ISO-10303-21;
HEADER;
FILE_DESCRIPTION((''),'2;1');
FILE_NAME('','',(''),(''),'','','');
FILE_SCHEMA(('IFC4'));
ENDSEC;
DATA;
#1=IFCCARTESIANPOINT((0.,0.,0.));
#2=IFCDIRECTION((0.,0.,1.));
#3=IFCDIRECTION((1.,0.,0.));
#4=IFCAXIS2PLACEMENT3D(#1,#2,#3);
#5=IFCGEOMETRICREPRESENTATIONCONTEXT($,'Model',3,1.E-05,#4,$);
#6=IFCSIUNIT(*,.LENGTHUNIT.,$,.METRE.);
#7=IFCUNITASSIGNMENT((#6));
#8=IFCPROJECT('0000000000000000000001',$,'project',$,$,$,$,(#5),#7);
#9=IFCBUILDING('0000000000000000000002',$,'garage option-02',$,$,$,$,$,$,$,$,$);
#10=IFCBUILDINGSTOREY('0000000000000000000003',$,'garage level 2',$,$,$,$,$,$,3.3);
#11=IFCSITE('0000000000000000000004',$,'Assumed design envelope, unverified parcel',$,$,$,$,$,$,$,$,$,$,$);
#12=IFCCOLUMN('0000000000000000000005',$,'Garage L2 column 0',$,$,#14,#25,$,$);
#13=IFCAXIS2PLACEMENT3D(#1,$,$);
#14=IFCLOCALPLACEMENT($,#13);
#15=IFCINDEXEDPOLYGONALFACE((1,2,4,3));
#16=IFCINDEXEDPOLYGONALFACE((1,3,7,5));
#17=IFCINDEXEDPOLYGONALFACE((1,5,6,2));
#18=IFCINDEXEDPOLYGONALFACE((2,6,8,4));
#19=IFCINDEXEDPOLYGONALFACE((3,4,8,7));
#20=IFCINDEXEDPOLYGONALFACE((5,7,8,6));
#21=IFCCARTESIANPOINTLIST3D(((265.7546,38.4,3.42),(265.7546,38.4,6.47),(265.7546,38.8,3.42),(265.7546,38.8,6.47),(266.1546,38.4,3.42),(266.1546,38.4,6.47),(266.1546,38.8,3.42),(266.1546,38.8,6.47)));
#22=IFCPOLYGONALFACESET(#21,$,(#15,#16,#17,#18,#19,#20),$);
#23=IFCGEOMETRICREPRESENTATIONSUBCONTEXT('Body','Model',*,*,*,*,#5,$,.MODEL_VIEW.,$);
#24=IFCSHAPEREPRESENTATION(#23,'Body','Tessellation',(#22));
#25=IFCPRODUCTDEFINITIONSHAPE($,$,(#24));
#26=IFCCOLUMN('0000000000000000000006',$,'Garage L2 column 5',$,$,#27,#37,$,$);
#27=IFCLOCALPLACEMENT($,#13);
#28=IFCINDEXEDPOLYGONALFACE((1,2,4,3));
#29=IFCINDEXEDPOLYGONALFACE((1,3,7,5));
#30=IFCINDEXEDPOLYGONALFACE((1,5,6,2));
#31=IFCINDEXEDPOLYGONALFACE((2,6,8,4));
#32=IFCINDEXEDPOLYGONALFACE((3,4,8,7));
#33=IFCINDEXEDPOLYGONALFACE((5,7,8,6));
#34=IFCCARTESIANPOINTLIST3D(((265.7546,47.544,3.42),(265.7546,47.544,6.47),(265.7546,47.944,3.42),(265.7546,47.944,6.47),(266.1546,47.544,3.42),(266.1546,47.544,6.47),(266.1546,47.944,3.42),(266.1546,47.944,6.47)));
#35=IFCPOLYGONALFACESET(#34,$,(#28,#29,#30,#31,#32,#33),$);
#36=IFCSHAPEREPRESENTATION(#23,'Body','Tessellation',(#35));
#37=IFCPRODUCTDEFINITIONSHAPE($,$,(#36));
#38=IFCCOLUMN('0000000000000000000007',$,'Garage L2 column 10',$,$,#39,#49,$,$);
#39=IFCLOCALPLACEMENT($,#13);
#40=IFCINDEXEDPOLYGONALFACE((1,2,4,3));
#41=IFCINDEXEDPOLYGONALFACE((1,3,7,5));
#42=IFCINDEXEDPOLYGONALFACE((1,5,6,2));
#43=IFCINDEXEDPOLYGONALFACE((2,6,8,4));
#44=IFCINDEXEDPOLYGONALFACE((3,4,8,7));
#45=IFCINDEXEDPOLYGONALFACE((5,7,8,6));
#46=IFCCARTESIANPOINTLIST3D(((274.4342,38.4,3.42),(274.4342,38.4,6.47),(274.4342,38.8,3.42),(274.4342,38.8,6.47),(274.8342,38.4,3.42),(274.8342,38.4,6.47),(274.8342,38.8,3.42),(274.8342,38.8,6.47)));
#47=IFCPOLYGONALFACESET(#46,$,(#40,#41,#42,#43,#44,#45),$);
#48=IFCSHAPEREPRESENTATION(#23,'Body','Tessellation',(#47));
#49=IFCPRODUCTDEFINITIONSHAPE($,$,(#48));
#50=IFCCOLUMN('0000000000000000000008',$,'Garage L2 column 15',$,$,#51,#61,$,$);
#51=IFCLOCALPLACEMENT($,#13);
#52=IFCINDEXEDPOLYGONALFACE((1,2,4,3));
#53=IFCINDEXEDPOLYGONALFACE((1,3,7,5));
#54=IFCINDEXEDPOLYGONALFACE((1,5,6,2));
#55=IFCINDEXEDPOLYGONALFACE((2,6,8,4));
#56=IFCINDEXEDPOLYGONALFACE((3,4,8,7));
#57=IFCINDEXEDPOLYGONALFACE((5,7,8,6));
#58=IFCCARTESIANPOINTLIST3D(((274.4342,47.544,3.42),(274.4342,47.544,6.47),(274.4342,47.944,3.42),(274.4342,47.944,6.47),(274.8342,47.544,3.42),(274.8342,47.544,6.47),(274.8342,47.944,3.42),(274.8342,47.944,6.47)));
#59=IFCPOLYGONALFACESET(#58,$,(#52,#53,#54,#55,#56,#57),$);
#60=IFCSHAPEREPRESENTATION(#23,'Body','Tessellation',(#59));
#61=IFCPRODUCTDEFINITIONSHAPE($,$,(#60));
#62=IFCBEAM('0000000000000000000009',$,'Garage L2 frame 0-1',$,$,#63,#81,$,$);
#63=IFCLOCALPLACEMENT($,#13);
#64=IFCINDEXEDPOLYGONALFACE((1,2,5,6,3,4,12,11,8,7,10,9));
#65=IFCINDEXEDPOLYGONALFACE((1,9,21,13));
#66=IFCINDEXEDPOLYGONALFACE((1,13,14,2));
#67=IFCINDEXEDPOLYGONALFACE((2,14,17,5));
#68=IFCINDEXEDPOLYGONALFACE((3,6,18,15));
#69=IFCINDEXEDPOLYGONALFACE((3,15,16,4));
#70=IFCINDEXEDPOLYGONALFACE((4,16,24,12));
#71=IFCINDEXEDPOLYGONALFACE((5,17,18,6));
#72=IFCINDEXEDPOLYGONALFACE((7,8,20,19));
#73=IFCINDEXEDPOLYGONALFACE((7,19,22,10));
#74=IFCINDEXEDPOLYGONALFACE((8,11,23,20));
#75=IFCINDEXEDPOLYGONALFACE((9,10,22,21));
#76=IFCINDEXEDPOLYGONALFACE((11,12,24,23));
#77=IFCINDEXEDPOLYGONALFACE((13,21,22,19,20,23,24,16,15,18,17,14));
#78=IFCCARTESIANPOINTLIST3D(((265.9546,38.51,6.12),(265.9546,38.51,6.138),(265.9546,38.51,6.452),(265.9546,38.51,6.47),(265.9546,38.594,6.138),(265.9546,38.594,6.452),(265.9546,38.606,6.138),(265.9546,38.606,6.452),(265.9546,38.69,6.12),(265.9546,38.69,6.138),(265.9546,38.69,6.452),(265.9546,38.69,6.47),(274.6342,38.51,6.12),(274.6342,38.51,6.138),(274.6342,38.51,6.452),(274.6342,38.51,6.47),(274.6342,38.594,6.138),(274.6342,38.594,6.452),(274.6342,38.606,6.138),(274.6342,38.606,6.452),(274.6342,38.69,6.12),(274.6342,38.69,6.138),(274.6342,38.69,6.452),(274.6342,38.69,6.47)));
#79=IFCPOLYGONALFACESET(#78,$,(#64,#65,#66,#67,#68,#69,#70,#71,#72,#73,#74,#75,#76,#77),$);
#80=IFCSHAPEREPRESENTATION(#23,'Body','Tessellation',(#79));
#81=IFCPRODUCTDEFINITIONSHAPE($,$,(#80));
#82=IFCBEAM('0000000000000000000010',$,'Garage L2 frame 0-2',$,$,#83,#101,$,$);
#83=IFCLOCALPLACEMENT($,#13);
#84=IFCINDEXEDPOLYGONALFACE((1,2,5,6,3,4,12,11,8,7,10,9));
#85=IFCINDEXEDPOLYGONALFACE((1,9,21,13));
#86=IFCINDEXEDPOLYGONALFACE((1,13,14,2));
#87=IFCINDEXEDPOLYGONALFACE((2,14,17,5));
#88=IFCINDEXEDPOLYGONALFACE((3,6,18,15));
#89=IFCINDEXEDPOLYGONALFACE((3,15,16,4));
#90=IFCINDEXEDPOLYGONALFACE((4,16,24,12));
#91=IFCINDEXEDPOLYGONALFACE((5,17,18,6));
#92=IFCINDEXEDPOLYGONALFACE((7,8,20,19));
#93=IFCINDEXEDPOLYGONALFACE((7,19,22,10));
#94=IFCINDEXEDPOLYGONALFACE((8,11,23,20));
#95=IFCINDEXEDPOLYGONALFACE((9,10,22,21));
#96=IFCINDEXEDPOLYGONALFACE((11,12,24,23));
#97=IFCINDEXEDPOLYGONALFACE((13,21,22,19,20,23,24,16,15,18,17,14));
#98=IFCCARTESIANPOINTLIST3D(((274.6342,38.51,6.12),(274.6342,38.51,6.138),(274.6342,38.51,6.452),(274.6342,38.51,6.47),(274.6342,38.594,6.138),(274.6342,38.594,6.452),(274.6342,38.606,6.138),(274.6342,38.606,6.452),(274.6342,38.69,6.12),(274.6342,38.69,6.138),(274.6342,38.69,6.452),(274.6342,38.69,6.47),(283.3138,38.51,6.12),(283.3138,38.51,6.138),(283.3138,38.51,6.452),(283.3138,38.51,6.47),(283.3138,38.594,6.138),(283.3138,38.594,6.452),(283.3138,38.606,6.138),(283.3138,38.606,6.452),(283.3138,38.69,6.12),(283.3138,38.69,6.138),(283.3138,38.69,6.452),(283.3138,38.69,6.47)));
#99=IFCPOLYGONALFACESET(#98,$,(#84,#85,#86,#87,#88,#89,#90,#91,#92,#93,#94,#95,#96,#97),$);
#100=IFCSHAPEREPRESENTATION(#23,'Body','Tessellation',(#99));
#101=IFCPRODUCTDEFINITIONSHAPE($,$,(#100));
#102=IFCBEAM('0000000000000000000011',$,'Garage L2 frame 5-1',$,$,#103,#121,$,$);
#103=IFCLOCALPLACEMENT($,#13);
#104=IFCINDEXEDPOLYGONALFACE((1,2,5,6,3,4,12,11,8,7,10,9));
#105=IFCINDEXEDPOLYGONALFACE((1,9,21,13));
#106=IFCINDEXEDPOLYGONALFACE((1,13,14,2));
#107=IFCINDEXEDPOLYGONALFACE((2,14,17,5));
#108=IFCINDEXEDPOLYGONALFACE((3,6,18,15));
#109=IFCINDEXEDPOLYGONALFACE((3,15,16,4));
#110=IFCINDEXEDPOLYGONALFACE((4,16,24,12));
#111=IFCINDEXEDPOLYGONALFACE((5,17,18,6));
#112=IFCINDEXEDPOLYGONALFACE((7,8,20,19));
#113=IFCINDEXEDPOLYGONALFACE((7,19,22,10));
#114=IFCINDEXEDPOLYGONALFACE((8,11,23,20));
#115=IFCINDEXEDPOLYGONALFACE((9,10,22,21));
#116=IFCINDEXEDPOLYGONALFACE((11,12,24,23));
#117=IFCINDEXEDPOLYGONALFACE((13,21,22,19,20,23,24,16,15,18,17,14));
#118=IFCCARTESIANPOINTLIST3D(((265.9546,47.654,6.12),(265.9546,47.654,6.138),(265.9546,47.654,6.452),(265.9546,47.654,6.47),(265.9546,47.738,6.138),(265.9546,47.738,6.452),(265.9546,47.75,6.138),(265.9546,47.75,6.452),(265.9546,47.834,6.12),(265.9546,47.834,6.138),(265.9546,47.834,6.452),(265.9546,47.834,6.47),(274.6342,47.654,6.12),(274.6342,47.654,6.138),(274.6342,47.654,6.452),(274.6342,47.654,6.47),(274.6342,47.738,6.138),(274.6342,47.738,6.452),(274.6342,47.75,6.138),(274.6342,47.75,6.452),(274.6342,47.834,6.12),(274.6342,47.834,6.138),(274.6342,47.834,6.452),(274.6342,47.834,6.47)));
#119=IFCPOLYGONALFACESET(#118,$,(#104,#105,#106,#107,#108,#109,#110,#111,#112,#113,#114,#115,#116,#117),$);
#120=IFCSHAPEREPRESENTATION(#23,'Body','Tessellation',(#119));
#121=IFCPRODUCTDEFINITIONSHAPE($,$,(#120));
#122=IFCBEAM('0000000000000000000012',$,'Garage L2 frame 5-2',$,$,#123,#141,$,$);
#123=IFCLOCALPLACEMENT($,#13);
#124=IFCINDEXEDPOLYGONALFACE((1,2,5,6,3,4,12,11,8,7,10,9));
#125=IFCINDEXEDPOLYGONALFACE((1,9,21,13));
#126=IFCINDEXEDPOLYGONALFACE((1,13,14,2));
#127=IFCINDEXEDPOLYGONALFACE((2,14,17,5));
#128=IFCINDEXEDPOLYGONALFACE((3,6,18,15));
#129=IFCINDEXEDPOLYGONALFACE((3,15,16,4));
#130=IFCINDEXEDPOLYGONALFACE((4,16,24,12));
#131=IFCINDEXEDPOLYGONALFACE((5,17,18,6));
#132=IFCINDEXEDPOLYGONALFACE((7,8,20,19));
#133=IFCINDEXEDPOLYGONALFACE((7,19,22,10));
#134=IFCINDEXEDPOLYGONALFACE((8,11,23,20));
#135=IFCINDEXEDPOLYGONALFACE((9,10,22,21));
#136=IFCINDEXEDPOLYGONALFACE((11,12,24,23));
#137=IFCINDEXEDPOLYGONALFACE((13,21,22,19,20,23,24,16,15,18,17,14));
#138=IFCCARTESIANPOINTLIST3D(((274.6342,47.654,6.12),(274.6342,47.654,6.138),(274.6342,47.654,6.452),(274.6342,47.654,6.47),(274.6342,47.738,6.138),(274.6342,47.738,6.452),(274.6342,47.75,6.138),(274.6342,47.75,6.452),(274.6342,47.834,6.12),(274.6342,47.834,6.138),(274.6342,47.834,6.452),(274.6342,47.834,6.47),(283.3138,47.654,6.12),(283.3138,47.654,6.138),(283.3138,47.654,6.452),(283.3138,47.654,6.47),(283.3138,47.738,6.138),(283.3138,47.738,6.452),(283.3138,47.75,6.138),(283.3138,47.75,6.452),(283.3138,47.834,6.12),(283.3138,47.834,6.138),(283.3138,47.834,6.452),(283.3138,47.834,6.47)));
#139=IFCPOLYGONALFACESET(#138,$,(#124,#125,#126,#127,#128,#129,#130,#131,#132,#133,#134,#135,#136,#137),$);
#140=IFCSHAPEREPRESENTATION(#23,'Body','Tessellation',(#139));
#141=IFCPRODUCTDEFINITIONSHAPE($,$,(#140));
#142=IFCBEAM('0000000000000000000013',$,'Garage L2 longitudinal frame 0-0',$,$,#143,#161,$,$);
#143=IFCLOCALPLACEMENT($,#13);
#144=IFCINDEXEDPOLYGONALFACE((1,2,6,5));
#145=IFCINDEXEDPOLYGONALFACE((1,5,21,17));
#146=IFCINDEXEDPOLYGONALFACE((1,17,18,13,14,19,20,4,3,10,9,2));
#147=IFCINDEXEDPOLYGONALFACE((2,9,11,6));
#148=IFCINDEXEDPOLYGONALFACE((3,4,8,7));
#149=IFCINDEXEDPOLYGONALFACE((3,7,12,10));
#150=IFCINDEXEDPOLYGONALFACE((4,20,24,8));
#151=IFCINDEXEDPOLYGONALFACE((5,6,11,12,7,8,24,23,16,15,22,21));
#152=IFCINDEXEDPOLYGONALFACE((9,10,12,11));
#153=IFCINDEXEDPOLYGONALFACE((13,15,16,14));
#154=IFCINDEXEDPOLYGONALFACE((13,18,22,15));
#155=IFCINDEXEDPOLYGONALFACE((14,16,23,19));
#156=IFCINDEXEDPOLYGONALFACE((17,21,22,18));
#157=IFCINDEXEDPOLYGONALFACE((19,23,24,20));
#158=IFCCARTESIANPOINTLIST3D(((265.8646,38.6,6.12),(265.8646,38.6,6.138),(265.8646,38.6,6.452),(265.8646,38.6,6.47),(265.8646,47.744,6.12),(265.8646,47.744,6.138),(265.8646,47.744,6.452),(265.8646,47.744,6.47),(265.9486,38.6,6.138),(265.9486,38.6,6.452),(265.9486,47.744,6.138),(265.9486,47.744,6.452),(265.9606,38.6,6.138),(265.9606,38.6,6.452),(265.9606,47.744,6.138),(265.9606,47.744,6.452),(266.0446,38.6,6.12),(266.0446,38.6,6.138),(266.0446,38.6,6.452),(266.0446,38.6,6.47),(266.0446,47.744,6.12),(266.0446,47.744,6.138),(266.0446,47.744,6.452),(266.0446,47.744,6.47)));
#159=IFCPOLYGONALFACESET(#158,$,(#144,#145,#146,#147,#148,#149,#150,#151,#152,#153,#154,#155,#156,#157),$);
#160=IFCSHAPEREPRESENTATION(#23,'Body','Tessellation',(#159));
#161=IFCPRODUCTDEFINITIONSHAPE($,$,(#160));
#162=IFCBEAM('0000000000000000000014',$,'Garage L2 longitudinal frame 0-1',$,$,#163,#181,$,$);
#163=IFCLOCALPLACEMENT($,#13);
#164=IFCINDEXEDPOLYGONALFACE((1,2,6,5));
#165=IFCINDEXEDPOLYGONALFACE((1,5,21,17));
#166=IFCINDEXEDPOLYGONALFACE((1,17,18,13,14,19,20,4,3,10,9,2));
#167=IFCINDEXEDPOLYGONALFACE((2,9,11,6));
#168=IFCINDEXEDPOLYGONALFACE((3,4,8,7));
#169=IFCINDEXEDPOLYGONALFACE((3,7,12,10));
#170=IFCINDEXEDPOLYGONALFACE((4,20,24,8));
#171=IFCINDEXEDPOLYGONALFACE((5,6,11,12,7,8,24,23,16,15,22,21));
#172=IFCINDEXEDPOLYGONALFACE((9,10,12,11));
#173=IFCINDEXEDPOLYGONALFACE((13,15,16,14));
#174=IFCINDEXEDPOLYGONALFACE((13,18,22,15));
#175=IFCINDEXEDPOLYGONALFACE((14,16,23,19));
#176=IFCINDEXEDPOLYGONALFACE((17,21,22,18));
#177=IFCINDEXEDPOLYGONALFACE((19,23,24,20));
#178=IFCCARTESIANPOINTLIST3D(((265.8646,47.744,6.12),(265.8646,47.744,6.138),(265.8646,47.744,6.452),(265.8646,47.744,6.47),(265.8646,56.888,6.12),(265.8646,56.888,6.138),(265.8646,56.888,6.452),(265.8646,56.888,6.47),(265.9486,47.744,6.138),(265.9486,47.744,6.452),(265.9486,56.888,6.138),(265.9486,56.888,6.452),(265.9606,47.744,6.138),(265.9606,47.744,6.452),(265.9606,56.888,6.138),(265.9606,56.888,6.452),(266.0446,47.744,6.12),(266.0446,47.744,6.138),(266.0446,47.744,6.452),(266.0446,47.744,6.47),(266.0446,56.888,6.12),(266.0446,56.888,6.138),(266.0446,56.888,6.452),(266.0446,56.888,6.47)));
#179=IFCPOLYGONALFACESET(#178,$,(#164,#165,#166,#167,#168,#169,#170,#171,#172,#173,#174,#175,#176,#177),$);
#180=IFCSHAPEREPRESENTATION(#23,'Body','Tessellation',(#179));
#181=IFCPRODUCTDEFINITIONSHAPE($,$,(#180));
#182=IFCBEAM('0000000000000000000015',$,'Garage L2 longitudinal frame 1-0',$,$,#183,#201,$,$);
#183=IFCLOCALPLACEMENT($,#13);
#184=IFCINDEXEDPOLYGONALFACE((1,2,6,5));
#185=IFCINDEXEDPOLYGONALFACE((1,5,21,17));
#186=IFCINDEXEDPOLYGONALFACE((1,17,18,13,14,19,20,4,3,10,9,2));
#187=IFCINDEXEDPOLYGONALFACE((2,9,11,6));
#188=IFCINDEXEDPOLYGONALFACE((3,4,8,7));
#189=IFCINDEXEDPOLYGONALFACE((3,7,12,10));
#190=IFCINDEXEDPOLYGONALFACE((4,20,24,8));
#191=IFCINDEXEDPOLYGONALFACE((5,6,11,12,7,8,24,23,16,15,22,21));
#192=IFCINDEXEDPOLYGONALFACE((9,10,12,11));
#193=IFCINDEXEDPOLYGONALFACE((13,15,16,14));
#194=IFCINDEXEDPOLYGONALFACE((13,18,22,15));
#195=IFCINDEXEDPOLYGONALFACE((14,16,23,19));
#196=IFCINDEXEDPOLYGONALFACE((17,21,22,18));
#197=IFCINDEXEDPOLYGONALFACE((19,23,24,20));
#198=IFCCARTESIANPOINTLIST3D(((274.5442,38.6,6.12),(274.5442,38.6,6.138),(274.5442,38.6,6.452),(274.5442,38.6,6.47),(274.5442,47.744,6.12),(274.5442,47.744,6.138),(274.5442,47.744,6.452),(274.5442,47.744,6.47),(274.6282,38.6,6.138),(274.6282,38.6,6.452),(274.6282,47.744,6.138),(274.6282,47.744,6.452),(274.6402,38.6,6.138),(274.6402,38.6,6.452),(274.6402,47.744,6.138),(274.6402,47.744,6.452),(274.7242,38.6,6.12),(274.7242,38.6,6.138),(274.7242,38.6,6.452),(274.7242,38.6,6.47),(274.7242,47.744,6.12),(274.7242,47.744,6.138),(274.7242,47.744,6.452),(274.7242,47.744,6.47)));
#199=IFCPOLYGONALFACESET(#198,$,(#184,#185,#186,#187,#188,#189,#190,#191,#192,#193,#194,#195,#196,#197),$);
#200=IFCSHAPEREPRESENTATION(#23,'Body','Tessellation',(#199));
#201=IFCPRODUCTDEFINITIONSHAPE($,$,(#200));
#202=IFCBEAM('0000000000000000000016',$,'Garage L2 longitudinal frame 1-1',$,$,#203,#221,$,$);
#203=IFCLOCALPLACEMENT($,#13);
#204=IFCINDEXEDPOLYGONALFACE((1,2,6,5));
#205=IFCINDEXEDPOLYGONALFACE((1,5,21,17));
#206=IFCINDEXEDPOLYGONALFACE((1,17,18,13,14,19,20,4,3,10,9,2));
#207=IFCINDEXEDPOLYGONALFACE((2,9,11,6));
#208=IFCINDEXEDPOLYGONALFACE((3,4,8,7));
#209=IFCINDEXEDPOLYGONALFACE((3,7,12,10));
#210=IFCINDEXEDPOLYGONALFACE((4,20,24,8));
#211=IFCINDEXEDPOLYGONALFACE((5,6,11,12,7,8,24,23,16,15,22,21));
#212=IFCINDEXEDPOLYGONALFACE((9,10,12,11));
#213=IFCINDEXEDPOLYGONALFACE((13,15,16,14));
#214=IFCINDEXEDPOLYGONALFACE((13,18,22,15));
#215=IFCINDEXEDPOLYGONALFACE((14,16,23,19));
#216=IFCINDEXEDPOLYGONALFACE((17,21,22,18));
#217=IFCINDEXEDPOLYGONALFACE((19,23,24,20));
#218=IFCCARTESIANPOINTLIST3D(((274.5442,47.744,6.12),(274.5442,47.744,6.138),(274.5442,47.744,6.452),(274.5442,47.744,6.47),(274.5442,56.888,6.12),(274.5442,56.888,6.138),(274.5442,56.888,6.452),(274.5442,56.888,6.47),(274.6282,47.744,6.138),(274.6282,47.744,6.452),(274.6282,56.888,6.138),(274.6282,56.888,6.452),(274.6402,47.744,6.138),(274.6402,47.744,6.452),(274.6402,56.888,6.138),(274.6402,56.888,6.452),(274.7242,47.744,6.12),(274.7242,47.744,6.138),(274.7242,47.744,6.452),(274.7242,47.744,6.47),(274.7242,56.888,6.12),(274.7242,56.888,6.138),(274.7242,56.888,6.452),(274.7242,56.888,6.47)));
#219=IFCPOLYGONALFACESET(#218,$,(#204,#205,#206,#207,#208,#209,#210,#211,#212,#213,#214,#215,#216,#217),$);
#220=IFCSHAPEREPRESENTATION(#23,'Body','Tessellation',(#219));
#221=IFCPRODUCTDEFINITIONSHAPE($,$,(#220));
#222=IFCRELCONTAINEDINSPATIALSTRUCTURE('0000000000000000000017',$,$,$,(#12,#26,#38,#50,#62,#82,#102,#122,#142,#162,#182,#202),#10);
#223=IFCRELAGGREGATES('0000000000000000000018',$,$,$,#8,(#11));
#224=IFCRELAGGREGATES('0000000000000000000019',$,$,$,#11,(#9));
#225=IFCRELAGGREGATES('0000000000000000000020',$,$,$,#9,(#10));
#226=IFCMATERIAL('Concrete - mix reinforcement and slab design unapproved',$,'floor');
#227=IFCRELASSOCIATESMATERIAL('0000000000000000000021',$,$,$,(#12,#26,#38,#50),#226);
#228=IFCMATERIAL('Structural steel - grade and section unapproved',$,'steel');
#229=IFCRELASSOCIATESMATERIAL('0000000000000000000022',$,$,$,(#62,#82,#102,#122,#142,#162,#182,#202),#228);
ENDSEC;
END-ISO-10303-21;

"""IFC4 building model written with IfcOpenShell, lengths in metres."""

from ifc_helpers import new_model, si_unit, frame, origin_with_axes, place, context, subcontext, project, spatial, rectangle, i_section, extrude, material, element, save


model = new_model("IFC4")

# Units and contexts
model_context = context("Model", 3, precision=1e-05, world=origin_with_axes())
body_context = subcontext(model_context, "Body", "Model", "MODEL_VIEW")
ifc_project = project(units=[si_unit("LENGTHUNIT", "METRE")], contexts=[model_context])

# Site, building, storey
site = spatial("IfcSite", under=ifc_project, Name="Assumed design envelope, unverified parcel")
building = spatial("IfcBuilding", under=site, Name="garage option-02")
storey = spatial("IfcBuildingStorey", under=building, Name="garage level 2", Elevation=3.3)

# Columns
ifc_material_1 = material(Name="Concrete - mix reinforcement and slab design unapproved", Category="floor")
for number, where, z_axis, x_axis, name in (
    (1, (265.9546, 38.6, 3.42), (0.0, 0.0, 1.0), (1.0, 0.0, 0.0), "Garage L2 column 0"),
    (2, (265.9546, 47.744, 3.42), (0.0, 0.0, 1.0), (1.0, 0.0, 0.0), "Garage L2 column 5"),
    (3, (274.6342, 38.6, 3.42), (0.0, 0.0, 1.0), (1.0, 0.0, 0.0), "Garage L2 column 10"),
    (4, (274.6342, 47.744, 3.42), (0.0, 0.0, 1.0), (1.0, 0.0, 0.0), "Garage L2 column 15"),
):
    element("IfcColumn", number, at=place(None, frame(where, z_axis=z_axis, x_axis=x_axis)), inside=storey, material=ifc_material_1, Name=name, context=body_context, shape_type="SweptSolid", body=[
        extrude(rectangle(XDim=0.4, YDim=0.4), origin_with_axes(), (0.0, 0.0, 1.0), 3.05),
    ])

# Beams
ifc_material_2 = material(Name="Structural steel - grade and section unapproved", Category="steel")
beam_1_placement = place(None, frame((265.9546, 38.6, 6.295), z_axis=(1.0, 0.0, 0.0), x_axis=(0.0, 1.0, 0.0)))
element("IfcBeam", 5, at=beam_1_placement, inside=storey, material=ifc_material_2, Name="Garage L2 frame 0-1", context=body_context, shape_type="SweptSolid", body=[
    extrude(i_section(OverallWidth=0.18, OverallDepth=0.35, WebThickness=0.012, FlangeThickness=0.018, FilletRadius=0.0), origin_with_axes(), (0.0, 0.0, 1.0), 8.6796),
])
beam_2_placement = place(None, frame((274.6342, 38.6, 6.295), z_axis=(1.0, 0.0, 0.0), x_axis=(0.0, 1.0, 0.0)))
element("IfcBeam", 6, at=beam_2_placement, inside=storey, material=ifc_material_2, Name="Garage L2 frame 0-2", context=body_context, shape_type="SweptSolid", body=[
    extrude(i_section(OverallWidth=0.18, OverallDepth=0.35, WebThickness=0.012, FlangeThickness=0.018, FilletRadius=0.0), origin_with_axes(), (0.0, 0.0, 1.0), 8.6796),
])
beam_3_placement = place(None, frame((265.9546, 47.744, 6.295), z_axis=(1.0, 0.0, 0.0), x_axis=(0.0, 1.0, 0.0)))
element("IfcBeam", 7, at=beam_3_placement, inside=storey, material=ifc_material_2, Name="Garage L2 frame 5-1", context=body_context, shape_type="SweptSolid", body=[
    extrude(i_section(OverallWidth=0.18, OverallDepth=0.35, WebThickness=0.012, FlangeThickness=0.018, FilletRadius=0.0), origin_with_axes(), (0.0, 0.0, 1.0), 8.6796),
])
beam_4_placement = place(None, frame((274.6342, 47.744, 6.295), z_axis=(1.0, 0.0, 0.0), x_axis=(0.0, 1.0, 0.0)))
element("IfcBeam", 8, at=beam_4_placement, inside=storey, material=ifc_material_2, Name="Garage L2 frame 5-2", context=body_context, shape_type="SweptSolid", body=[
    extrude(i_section(OverallWidth=0.18, OverallDepth=0.35, WebThickness=0.012, FlangeThickness=0.018, FilletRadius=0.0), origin_with_axes(), (0.0, 0.0, 1.0), 8.6796),
])
for number, where, z_axis, x_axis, name in (
    (9, (265.9546, 38.6, 6.295), (0.0, 1.0, 0.0), (-1.0, 0.0, 0.0), "Garage L2 longitudinal frame 0-0"),
    (10, (265.9546, 47.744, 6.295), (0.0, 1.0, 0.0), (-1.0, 0.0, 0.0), "Garage L2 longitudinal frame 0-1"),
    (11, (274.6342, 38.6, 6.295), (0.0, 1.0, 0.0), (-1.0, 0.0, 0.0), "Garage L2 longitudinal frame 1-0"),
    (12, (274.6342, 47.744, 6.295), (0.0, 1.0, 0.0), (-1.0, 0.0, 0.0), "Garage L2 longitudinal frame 1-1"),
):
    element("IfcBeam", number, at=place(None, frame(where, z_axis=z_axis, x_axis=x_axis)), inside=storey, material=ifc_material_2, Name=name, context=body_context, shape_type="SweptSolid", body=[
        extrude(i_section(OverallWidth=0.18, OverallDepth=0.35, WebThickness=0.012, FlangeThickness=0.018, FilletRadius=0.0), origin_with_axes(), (0.0, 0.0, 1.0), 9.144),
    ])

save(model, "model.ifc")
